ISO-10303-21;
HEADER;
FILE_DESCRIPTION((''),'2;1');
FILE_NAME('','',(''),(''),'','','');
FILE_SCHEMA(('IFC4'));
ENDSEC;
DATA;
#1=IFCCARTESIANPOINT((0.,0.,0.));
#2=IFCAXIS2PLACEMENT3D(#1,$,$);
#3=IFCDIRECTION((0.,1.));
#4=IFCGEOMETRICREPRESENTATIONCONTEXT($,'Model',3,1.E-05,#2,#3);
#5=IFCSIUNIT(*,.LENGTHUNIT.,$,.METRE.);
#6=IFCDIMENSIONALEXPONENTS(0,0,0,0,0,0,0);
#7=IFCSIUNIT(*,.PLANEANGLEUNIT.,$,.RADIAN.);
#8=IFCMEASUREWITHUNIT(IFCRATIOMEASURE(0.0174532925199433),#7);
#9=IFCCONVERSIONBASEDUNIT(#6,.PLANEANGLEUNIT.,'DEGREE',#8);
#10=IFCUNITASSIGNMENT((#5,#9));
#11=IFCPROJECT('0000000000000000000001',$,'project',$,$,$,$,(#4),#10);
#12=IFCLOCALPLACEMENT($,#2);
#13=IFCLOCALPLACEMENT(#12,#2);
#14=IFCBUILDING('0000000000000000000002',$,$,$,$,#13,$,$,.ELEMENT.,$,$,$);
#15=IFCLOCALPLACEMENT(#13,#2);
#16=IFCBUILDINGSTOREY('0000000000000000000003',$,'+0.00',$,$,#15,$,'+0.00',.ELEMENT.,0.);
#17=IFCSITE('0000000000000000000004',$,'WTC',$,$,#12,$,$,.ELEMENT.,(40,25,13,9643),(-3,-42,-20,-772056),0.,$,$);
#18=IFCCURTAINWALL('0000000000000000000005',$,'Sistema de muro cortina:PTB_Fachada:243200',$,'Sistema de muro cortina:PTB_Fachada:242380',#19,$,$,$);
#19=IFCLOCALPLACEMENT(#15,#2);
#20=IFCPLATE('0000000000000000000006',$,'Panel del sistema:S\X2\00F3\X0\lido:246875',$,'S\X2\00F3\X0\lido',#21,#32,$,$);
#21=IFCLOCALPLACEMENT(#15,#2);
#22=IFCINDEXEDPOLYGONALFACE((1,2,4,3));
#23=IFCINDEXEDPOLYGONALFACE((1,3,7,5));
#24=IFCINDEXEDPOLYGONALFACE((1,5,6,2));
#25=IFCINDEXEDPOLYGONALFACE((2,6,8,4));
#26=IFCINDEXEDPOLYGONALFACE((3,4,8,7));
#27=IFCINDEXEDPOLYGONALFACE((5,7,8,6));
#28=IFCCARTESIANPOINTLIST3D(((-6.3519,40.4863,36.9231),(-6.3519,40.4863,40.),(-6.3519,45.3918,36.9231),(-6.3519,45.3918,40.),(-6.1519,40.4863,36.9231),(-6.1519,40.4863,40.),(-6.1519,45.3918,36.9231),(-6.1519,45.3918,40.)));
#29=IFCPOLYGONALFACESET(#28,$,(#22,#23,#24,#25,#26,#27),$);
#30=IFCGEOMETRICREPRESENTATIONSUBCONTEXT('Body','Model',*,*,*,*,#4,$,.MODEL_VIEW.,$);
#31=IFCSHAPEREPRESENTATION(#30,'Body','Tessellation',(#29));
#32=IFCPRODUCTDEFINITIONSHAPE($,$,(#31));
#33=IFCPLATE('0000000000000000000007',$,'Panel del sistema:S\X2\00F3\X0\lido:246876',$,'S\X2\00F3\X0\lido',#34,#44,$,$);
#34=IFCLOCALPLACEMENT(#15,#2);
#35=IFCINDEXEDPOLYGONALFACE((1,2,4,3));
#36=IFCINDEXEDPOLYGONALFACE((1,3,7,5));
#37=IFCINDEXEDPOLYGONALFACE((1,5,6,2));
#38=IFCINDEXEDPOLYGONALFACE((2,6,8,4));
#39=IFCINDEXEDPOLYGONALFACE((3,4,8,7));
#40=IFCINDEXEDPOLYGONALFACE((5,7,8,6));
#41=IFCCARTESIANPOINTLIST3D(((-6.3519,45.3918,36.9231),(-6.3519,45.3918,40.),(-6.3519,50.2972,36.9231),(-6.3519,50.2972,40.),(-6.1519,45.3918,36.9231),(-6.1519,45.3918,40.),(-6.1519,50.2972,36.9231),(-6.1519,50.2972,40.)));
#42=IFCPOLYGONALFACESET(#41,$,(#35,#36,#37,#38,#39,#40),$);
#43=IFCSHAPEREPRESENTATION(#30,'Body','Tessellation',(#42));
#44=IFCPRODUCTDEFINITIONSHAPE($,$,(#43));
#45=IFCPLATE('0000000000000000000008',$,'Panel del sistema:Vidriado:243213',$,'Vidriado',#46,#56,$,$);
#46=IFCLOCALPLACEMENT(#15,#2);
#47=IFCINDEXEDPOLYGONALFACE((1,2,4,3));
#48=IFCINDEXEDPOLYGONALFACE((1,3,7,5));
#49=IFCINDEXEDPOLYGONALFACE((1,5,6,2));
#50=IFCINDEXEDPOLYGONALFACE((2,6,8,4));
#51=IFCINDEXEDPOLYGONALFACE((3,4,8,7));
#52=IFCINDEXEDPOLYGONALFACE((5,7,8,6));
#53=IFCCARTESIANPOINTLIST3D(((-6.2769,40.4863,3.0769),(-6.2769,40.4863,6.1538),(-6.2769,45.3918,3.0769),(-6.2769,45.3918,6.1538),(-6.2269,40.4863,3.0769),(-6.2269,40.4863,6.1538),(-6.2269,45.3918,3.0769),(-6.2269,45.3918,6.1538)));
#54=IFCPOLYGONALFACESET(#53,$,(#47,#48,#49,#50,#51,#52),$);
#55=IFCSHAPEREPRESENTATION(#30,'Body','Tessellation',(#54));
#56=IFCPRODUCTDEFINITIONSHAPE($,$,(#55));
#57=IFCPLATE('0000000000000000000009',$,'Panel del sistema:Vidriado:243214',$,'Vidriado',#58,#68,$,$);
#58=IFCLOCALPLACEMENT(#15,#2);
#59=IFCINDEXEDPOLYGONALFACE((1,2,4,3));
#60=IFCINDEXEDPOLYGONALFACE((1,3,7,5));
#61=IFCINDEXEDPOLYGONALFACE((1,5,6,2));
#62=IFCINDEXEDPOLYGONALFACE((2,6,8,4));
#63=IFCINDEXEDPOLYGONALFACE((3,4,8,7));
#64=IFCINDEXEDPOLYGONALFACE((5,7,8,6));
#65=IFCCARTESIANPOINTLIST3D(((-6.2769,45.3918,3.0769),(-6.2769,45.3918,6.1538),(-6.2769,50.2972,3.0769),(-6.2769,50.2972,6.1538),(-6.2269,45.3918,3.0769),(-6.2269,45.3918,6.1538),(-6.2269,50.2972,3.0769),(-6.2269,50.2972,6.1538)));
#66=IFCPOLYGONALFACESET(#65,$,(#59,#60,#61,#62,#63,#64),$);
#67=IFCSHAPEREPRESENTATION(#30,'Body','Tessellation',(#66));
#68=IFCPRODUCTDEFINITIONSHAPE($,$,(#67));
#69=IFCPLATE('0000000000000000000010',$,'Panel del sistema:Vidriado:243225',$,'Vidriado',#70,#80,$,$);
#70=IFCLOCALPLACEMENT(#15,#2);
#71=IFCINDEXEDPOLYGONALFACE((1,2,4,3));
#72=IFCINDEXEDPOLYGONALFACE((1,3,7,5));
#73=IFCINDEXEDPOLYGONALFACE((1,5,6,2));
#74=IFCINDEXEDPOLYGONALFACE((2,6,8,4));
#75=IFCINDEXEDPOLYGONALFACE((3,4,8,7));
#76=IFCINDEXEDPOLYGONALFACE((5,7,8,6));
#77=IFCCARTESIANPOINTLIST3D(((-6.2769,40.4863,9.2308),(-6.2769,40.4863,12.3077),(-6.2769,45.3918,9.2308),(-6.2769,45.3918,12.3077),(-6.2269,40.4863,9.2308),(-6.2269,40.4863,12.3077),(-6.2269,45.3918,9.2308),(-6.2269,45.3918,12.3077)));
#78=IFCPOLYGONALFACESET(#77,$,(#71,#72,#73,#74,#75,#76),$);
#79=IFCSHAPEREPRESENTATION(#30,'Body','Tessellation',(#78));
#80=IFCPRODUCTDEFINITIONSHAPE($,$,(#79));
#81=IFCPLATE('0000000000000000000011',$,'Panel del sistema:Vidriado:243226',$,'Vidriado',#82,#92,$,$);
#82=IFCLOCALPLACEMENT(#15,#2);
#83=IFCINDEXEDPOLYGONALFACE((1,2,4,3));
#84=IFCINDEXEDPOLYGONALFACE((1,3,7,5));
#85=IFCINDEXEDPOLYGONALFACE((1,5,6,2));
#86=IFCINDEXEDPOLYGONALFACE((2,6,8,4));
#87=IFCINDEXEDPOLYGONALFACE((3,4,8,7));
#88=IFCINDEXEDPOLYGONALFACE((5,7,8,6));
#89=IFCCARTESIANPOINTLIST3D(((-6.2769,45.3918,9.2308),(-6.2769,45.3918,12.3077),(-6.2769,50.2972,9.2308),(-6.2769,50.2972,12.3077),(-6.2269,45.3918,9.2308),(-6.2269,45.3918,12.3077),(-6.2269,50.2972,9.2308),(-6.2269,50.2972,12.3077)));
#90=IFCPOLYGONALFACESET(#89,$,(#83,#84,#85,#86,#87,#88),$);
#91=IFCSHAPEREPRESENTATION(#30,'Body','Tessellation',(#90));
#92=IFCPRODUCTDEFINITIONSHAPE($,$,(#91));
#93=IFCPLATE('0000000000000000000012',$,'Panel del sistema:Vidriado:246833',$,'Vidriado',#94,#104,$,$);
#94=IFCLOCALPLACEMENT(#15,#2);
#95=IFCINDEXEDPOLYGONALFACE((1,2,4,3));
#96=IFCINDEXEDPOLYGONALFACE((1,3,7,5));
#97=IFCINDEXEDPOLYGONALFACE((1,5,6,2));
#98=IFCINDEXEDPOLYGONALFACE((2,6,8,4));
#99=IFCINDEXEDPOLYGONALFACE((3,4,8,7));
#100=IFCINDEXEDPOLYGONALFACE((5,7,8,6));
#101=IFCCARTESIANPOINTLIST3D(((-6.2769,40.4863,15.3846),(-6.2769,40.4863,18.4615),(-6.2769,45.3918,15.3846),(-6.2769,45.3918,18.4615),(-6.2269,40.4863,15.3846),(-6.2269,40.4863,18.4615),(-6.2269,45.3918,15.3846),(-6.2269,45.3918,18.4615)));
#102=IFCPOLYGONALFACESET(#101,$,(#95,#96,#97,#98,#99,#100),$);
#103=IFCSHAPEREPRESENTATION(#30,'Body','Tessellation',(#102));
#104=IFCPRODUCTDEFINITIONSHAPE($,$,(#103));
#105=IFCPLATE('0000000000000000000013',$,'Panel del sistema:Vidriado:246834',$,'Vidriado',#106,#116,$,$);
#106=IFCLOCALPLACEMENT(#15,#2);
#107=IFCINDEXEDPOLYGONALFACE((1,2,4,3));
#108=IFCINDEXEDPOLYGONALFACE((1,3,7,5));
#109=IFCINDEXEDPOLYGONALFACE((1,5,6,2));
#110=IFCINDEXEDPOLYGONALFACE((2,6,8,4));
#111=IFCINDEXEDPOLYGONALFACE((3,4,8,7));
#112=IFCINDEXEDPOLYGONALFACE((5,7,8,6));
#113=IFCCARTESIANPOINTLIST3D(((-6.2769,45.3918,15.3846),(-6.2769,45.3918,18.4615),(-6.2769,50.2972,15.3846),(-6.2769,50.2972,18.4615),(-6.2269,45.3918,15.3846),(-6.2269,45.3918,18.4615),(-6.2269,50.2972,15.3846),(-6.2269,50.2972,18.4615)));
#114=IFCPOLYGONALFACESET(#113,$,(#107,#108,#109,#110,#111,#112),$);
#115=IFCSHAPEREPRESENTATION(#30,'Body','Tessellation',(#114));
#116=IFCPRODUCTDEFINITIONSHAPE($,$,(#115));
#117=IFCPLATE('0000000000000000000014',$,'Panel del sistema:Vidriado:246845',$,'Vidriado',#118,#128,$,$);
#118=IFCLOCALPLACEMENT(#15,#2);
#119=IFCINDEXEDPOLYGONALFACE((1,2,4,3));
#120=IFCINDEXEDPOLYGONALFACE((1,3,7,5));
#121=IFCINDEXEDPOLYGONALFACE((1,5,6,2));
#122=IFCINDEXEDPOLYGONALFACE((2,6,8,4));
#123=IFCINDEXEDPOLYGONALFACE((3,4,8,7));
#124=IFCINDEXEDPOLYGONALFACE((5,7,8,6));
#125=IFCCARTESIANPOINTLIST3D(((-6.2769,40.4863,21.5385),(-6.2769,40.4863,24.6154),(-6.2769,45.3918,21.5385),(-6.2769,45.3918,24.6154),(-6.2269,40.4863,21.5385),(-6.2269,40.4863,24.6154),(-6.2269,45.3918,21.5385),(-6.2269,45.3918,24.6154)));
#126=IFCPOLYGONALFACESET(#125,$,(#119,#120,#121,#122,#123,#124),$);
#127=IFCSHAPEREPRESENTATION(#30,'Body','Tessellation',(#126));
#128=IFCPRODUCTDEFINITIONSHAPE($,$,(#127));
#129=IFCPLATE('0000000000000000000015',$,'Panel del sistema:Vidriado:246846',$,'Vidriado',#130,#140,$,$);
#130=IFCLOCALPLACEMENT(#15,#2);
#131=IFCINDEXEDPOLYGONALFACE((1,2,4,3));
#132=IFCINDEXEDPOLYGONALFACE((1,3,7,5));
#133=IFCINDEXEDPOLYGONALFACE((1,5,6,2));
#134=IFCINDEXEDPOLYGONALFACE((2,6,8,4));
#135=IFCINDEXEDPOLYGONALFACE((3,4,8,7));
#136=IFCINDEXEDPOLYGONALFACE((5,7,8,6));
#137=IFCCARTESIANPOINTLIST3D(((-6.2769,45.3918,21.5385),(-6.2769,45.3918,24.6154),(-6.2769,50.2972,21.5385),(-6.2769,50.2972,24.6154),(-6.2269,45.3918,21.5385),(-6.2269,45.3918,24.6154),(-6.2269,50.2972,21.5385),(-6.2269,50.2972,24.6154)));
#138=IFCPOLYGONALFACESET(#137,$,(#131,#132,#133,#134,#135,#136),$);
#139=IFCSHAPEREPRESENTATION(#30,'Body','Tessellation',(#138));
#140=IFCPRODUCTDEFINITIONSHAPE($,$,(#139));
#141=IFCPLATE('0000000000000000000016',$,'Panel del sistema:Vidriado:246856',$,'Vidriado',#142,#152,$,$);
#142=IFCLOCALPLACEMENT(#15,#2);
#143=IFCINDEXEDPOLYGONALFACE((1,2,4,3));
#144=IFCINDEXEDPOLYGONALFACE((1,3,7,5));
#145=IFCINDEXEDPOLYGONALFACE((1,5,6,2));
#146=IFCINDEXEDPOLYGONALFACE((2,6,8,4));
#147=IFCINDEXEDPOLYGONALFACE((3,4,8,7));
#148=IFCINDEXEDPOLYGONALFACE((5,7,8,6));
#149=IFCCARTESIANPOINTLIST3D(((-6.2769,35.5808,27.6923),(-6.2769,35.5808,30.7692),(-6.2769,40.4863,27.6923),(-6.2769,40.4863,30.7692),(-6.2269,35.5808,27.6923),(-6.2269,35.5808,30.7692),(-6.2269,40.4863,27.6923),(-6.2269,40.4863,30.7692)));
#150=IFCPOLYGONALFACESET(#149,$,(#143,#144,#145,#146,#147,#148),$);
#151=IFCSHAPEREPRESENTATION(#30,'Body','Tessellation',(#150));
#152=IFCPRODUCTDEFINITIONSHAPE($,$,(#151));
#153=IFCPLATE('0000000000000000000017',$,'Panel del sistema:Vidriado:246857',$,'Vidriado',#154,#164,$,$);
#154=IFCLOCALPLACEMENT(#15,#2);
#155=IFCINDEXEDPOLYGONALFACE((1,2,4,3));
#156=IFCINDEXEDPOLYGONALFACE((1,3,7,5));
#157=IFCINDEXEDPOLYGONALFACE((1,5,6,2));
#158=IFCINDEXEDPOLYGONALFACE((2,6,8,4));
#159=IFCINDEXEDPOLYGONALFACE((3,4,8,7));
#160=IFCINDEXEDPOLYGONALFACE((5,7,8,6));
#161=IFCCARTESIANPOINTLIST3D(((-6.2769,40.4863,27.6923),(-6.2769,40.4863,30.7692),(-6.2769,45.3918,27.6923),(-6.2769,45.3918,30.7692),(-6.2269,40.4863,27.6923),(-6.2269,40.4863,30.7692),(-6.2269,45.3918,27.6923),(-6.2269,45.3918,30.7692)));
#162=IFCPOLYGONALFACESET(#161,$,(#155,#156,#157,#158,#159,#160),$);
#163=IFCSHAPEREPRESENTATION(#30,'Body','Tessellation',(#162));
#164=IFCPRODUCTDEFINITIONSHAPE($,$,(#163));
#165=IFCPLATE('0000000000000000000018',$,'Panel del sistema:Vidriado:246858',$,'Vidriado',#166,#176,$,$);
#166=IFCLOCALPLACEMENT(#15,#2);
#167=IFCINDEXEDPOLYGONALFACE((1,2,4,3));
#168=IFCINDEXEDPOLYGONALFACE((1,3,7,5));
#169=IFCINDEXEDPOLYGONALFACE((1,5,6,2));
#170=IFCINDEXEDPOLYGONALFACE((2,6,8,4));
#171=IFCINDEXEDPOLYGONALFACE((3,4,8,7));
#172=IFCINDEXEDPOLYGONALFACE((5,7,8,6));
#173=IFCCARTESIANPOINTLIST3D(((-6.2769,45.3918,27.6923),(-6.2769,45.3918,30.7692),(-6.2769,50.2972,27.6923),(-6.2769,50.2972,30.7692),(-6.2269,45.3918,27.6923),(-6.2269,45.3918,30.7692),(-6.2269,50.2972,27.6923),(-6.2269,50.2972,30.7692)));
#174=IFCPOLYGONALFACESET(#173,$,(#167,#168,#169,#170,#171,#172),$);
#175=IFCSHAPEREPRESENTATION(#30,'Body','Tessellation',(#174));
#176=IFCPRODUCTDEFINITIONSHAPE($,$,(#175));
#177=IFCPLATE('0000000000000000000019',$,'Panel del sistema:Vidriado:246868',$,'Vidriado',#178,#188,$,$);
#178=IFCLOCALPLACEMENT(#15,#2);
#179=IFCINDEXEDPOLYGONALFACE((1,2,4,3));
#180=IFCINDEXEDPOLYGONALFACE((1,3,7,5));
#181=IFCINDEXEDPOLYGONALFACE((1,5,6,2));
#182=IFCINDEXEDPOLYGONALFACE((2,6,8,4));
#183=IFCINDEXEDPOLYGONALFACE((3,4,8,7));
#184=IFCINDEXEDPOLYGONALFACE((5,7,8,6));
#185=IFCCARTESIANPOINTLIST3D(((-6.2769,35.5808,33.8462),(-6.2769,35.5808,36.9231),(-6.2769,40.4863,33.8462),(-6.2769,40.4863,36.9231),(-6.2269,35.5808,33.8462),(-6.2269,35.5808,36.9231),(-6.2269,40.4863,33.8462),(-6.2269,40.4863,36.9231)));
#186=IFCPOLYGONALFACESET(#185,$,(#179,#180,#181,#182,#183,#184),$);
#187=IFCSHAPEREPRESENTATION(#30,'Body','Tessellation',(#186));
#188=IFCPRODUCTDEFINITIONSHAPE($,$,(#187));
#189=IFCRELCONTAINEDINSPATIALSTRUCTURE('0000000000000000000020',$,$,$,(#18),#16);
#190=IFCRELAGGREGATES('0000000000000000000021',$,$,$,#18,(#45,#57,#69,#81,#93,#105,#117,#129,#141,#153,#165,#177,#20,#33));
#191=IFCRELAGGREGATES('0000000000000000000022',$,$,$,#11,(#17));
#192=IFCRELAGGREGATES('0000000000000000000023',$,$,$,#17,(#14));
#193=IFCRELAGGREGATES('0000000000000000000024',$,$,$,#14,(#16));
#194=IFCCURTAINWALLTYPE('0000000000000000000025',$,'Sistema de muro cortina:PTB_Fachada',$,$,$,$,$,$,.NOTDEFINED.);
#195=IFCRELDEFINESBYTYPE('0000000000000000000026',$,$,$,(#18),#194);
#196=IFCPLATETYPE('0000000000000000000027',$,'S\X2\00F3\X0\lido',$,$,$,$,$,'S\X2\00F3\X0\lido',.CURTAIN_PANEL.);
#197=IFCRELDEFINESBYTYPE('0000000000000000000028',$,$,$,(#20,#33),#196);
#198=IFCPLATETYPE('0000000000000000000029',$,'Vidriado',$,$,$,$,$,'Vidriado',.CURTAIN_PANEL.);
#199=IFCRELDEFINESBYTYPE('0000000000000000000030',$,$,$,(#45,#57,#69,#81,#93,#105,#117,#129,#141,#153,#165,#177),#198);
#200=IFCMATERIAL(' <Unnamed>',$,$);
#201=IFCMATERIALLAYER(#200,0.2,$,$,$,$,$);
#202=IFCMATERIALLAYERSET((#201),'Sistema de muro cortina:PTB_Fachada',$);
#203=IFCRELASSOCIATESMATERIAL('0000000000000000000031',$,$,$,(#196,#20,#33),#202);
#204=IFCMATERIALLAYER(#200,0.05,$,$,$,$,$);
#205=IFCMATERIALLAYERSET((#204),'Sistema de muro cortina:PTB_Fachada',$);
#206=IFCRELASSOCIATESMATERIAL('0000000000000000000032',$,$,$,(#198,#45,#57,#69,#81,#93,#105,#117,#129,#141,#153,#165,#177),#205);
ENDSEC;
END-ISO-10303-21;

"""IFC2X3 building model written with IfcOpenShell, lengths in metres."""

from ifc_helpers import new_model, entity, si_unit, converted_unit, direction, frame, origin, origin_2d_with_axis, place, context, subcontext, project, spatial, rectangle, extrude, source, transform, mapped, material, layer, layer_set, layer_usage, type_object, type_shapes, element, aggregate, save


model = new_model("IFC2X3")

# Units and contexts
model_context = context("Model", 3, precision=1e-05, world=origin(), true_north=direction((0.0, 1.0)))
body_context = subcontext(model_context, "Body", "Model", "MODEL_VIEW")
ifc_project = project(units=[si_unit("LENGTHUNIT", "METRE"), converted_unit("PLANEANGLEUNIT", "DEGREE", entity("IfcRatioMeasure", 0.0174532925199433), si_unit("PLANEANGLEUNIT", "RADIAN"), dimensions=[0, 0, 0, 0, 0, 0, 0])], contexts=[model_context])

# Site, building, storey
site_placement = place(None, origin())
site = spatial("IfcSite", under=ifc_project, at=site_placement, Name="WTC", CompositionType="ELEMENT", RefLatitude=(40, 25, 13, 9643), RefLongitude=(-3, -42, -20, -772056), RefElevation=0.0)
building_placement = place(site_placement, origin())
building = spatial("IfcBuilding", under=site, at=building_placement, CompositionType="ELEMENT")
storey_placement = place(building_placement, origin())
storey = spatial("IfcBuildingStorey", under=building, at=storey_placement, Name="+0.00", LongName="+0.00", CompositionType="ELEMENT", Elevation=0.0)

# Curtain wall, plates
curtain_wall_type = type_object("IfcCurtainWallType", Name="Sistema de muro cortina:PTB_Fachada", PredefinedType="NOTDEFINED")
curtain_wall_1_placement = place(storey_placement, origin())
curtain_wall_1 = element("IfcCurtainWall", 1, at=curtain_wall_1_placement, inside=storey, type_object=curtain_wall_type, Name="Sistema de muro cortina:PTB_Fachada:243200", ObjectType="Sistema de muro cortina:PTB_Fachada:242380")
ifc_material_1 = material(Name=" <Unnamed>")
ifc_layer_1 = layer(ifc_material_1, 0.2)
ifc_layer_set_1 = layer_set([ifc_layer_1], Name="Sistema de muro cortina:PTB_Fachada")
plate_type_1 = type_object("IfcPlateType", Name="Sólido", ElementType="Sólido", PredefinedType="CURTAIN_PANEL", material=ifc_layer_set_1)
shared_shape_1 = source(origin(), body_context, "Body", "SweptSolid", [
    extrude(rectangle(XDim=0.2, YDim=4.9055, at=origin_2d_with_axis()), frame((0.0, 0.0, 0.0), z_axis=(0.0, 0.0, 1.0), x_axis=(0.0, 1.0, 0.0)), (0.0, 0.0, 1.0), 3.0769),
])
type_shapes(plate_type_1, [shared_shape_1])
ifc_layer_usage_1 = layer_usage(ifc_layer_set_1, "AXIS3", "POSITIVE", 0.0)
plate_1_placement = place(curtain_wall_1_placement, frame((-6.2519, 42.939, 36.9231), z_axis=(0.0, 0.0, 1.0), x_axis=(0.0, 1.0, 0.0)))
plate_1 = element("IfcPlate", 2, at=plate_1_placement, type_object=plate_type_1, material=ifc_layer_usage_1, Name="Panel del sistema:Sólido:246875", ObjectType="Sólido", context=body_context, shape_type="MappedRepresentation", body=[
    mapped(shared_shape_1, transform((0.0, 0.0, 0.0), scale=1.0)),
])
ifc_layer_usage_2 = layer_usage(ifc_layer_set_1, "AXIS3", "POSITIVE", 0.0)
plate_2_placement = place(curtain_wall_1_placement, frame((-6.2519, 47.8445, 36.9231), z_axis=(0.0, 0.0, 1.0), x_axis=(0.0, 1.0, 0.0)))
plate_2 = element("IfcPlate", 3, at=plate_2_placement, type_object=plate_type_1, material=ifc_layer_usage_2, Name="Panel del sistema:Sólido:246876", ObjectType="Sólido", context=body_context, shape_type="MappedRepresentation", body=[
    mapped(shared_shape_1, transform((0.0, 0.0, 0.0), scale=1.0)),
])
ifc_layer_2 = layer(ifc_material_1, 0.05)
ifc_layer_set_2 = layer_set([ifc_layer_2], Name="Sistema de muro cortina:PTB_Fachada")
ifc_layer_usage_3 = layer_usage(ifc_layer_set_2, "AXIS3", "POSITIVE", 0.0)
plate_type_2 = type_object("IfcPlateType", Name="Vidriado", ElementType="Vidriado", PredefinedType="CURTAIN_PANEL", material=ifc_layer_set_2)
shared_shape_2 = source(origin(), body_context, "Body", "SweptSolid", [
    extrude(rectangle(XDim=0.05, YDim=4.9055, at=origin_2d_with_axis()), frame((0.0, 0.0, 0.0), z_axis=(0.0, 0.0, 1.0), x_axis=(0.0, 1.0, 0.0)), (0.0, 0.0, 1.0), 3.0769),
])
type_shapes(plate_type_2, [shared_shape_2])
plate_3_placement = place(curtain_wall_1_placement, frame((-6.2519, 42.939, 3.0769), z_axis=(0.0, 0.0, 1.0), x_axis=(0.0, 1.0, 0.0)))
plate_3 = element("IfcPlate", 4, at=plate_3_placement, type_object=plate_type_2, material=ifc_layer_usage_3, Name="Panel del sistema:Vidriado:243213", ObjectType="Vidriado", context=body_context, shape_type="MappedRepresentation", body=[
    mapped(shared_shape_2, transform((0.0, 0.0, 0.0), scale=1.0)),
])
ifc_layer_usage_4 = layer_usage(ifc_layer_set_2, "AXIS3", "POSITIVE", 0.0)
plate_4_placement = place(curtain_wall_1_placement, frame((-6.2519, 47.8445, 3.0769), z_axis=(0.0, 0.0, 1.0), x_axis=(0.0, 1.0, 0.0)))
plate_4 = element("IfcPlate", 5, at=plate_4_placement, type_object=plate_type_2, material=ifc_layer_usage_4, Name="Panel del sistema:Vidriado:243214", ObjectType="Vidriado", context=body_context, shape_type="MappedRepresentation", body=[
    mapped(shared_shape_2, transform((0.0, 0.0, 0.0), scale=1.0)),
])
ifc_layer_usage_5 = layer_usage(ifc_layer_set_2, "AXIS3", "POSITIVE", 0.0)
plate_5_placement = place(curtain_wall_1_placement, frame((-6.2519, 42.939, 9.2308), z_axis=(0.0, 0.0, 1.0), x_axis=(0.0, 1.0, 0.0)))
plate_5 = element("IfcPlate", 6, at=plate_5_placement, type_object=plate_type_2, material=ifc_layer_usage_5, Name="Panel del sistema:Vidriado:243225", ObjectType="Vidriado", context=body_context, shape_type="MappedRepresentation", body=[
    mapped(shared_shape_2, transform((0.0, 0.0, 0.0), scale=1.0)),
])
ifc_layer_usage_6 = layer_usage(ifc_layer_set_2, "AXIS3", "POSITIVE", 0.0)
plate_6_placement = place(curtain_wall_1_placement, frame((-6.2519, 47.8445, 9.2308), z_axis=(0.0, 0.0, 1.0), x_axis=(0.0, 1.0, 0.0)))
plate_6 = element("IfcPlate", 7, at=plate_6_placement, type_object=plate_type_2, material=ifc_layer_usage_6, Name="Panel del sistema:Vidriado:243226", ObjectType="Vidriado", context=body_context, shape_type="MappedRepresentation", body=[
    mapped(shared_shape_2, transform((0.0, 0.0, 0.0), scale=1.0)),
])
ifc_layer_usage_7 = layer_usage(ifc_layer_set_2, "AXIS3", "POSITIVE", 0.0)
plate_7_placement = place(curtain_wall_1_placement, frame((-6.2519, 42.939, 15.3846), z_axis=(0.0, 0.0, 1.0), x_axis=(0.0, 1.0, 0.0)))
plate_7 = element("IfcPlate", 8, at=plate_7_placement, type_object=plate_type_2, material=ifc_layer_usage_7, Name="Panel del sistema:Vidriado:246833", ObjectType="Vidriado", context=body_context, shape_type="MappedRepresentation", body=[
    mapped(shared_shape_2, transform((0.0, 0.0, 0.0), scale=1.0)),
])
ifc_layer_usage_8 = layer_usage(ifc_layer_set_2, "AXIS3", "POSITIVE", 0.0)
plate_8_placement = place(curtain_wall_1_placement, frame((-6.2519, 47.8445, 15.3846), z_axis=(0.0, 0.0, 1.0), x_axis=(0.0, 1.0, 0.0)))
plate_8 = element("IfcPlate", 9, at=plate_8_placement, type_object=plate_type_2, material=ifc_layer_usage_8, Name="Panel del sistema:Vidriado:246834", ObjectType="Vidriado", context=body_context, shape_type="MappedRepresentation", body=[
    mapped(shared_shape_2, transform((0.0, 0.0, 0.0), scale=1.0)),
])
ifc_layer_usage_9 = layer_usage(ifc_layer_set_2, "AXIS3", "POSITIVE", 0.0)
plate_9_placement = place(curtain_wall_1_placement, frame((-6.2519, 42.939, 21.5385), z_axis=(0.0, 0.0, 1.0), x_axis=(0.0, 1.0, 0.0)))
plate_9 = element("IfcPlate", 10, at=plate_9_placement, type_object=plate_type_2, material=ifc_layer_usage_9, Name="Panel del sistema:Vidriado:246845", ObjectType="Vidriado", context=body_context, shape_type="MappedRepresentation", body=[
    mapped(shared_shape_2, transform((0.0, 0.0, 0.0), scale=1.0)),
])
ifc_layer_usage_10 = layer_usage(ifc_layer_set_2, "AXIS3", "POSITIVE", 0.0)
plate_10_placement = place(curtain_wall_1_placement, frame((-6.2519, 47.8445, 21.5385), z_axis=(0.0, 0.0, 1.0), x_axis=(0.0, 1.0, 0.0)))
plate_10 = element("IfcPlate", 11, at=plate_10_placement, type_object=plate_type_2, material=ifc_layer_usage_10, Name="Panel del sistema:Vidriado:246846", ObjectType="Vidriado", context=body_context, shape_type="MappedRepresentation", body=[
    mapped(shared_shape_2, transform((0.0, 0.0, 0.0), scale=1.0)),
])
ifc_layer_usage_11 = layer_usage(ifc_layer_set_2, "AXIS3", "POSITIVE", 0.0)
plate_11_placement = place(curtain_wall_1_placement, frame((-6.2519, 38.0336, 27.6923), z_axis=(0.0, 0.0, 1.0), x_axis=(0.0, 1.0, 0.0)))
plate_11 = element("IfcPlate", 12, at=plate_11_placement, type_object=plate_type_2, material=ifc_layer_usage_11, Name="Panel del sistema:Vidriado:246856", ObjectType="Vidriado", context=body_context, shape_type="MappedRepresentation", body=[
    mapped(shared_shape_2, transform((0.0, 0.0, 0.0), scale=1.0)),
])
ifc_layer_usage_12 = layer_usage(ifc_layer_set_2, "AXIS3", "POSITIVE", 0.0)
plate_12_placement = place(curtain_wall_1_placement, frame((-6.2519, 42.939, 27.6923), z_axis=(0.0, 0.0, 1.0), x_axis=(0.0, 1.0, 0.0)))
plate_12 = element("IfcPlate", 13, at=plate_12_placement, type_object=plate_type_2, material=ifc_layer_usage_12, Name="Panel del sistema:Vidriado:246857", ObjectType="Vidriado", context=body_context, shape_type="MappedRepresentation", body=[
    mapped(shared_shape_2, transform((0.0, 0.0, 0.0), scale=1.0)),
])
ifc_layer_usage_13 = layer_usage(ifc_layer_set_2, "AXIS3", "POSITIVE", 0.0)
plate_13_placement = place(curtain_wall_1_placement, frame((-6.2519, 47.8445, 27.6923), z_axis=(0.0, 0.0, 1.0), x_axis=(0.0, 1.0, 0.0)))
plate_13 = element("IfcPlate", 14, at=plate_13_placement, type_object=plate_type_2, material=ifc_layer_usage_13, Name="Panel del sistema:Vidriado:246858", ObjectType="Vidriado", context=body_context, shape_type="MappedRepresentation", body=[
    mapped(shared_shape_2, transform((0.0, 0.0, 0.0), scale=1.0)),
])
ifc_layer_usage_14 = layer_usage(ifc_layer_set_2, "AXIS3", "POSITIVE", 0.0)
plate_14_placement = place(curtain_wall_1_placement, frame((-6.2519, 38.0336, 33.8462), z_axis=(0.0, 0.0, 1.0), x_axis=(0.0, 1.0, 0.0)))
plate_14 = element("IfcPlate", 15, at=plate_14_placement, type_object=plate_type_2, material=ifc_layer_usage_14, Name="Panel del sistema:Vidriado:246868", ObjectType="Vidriado", context=body_context, shape_type="MappedRepresentation", body=[
    mapped(shared_shape_2, transform((0.0, 0.0, 0.0), scale=1.0)),
])
aggregate(curtain_wall_1, [plate_3, plate_4, plate_5, plate_6, plate_7, plate_8, plate_9, plate_10, plate_11, plate_12, plate_13, plate_14, plate_1, plate_2])

save(model, "model.ifc")
